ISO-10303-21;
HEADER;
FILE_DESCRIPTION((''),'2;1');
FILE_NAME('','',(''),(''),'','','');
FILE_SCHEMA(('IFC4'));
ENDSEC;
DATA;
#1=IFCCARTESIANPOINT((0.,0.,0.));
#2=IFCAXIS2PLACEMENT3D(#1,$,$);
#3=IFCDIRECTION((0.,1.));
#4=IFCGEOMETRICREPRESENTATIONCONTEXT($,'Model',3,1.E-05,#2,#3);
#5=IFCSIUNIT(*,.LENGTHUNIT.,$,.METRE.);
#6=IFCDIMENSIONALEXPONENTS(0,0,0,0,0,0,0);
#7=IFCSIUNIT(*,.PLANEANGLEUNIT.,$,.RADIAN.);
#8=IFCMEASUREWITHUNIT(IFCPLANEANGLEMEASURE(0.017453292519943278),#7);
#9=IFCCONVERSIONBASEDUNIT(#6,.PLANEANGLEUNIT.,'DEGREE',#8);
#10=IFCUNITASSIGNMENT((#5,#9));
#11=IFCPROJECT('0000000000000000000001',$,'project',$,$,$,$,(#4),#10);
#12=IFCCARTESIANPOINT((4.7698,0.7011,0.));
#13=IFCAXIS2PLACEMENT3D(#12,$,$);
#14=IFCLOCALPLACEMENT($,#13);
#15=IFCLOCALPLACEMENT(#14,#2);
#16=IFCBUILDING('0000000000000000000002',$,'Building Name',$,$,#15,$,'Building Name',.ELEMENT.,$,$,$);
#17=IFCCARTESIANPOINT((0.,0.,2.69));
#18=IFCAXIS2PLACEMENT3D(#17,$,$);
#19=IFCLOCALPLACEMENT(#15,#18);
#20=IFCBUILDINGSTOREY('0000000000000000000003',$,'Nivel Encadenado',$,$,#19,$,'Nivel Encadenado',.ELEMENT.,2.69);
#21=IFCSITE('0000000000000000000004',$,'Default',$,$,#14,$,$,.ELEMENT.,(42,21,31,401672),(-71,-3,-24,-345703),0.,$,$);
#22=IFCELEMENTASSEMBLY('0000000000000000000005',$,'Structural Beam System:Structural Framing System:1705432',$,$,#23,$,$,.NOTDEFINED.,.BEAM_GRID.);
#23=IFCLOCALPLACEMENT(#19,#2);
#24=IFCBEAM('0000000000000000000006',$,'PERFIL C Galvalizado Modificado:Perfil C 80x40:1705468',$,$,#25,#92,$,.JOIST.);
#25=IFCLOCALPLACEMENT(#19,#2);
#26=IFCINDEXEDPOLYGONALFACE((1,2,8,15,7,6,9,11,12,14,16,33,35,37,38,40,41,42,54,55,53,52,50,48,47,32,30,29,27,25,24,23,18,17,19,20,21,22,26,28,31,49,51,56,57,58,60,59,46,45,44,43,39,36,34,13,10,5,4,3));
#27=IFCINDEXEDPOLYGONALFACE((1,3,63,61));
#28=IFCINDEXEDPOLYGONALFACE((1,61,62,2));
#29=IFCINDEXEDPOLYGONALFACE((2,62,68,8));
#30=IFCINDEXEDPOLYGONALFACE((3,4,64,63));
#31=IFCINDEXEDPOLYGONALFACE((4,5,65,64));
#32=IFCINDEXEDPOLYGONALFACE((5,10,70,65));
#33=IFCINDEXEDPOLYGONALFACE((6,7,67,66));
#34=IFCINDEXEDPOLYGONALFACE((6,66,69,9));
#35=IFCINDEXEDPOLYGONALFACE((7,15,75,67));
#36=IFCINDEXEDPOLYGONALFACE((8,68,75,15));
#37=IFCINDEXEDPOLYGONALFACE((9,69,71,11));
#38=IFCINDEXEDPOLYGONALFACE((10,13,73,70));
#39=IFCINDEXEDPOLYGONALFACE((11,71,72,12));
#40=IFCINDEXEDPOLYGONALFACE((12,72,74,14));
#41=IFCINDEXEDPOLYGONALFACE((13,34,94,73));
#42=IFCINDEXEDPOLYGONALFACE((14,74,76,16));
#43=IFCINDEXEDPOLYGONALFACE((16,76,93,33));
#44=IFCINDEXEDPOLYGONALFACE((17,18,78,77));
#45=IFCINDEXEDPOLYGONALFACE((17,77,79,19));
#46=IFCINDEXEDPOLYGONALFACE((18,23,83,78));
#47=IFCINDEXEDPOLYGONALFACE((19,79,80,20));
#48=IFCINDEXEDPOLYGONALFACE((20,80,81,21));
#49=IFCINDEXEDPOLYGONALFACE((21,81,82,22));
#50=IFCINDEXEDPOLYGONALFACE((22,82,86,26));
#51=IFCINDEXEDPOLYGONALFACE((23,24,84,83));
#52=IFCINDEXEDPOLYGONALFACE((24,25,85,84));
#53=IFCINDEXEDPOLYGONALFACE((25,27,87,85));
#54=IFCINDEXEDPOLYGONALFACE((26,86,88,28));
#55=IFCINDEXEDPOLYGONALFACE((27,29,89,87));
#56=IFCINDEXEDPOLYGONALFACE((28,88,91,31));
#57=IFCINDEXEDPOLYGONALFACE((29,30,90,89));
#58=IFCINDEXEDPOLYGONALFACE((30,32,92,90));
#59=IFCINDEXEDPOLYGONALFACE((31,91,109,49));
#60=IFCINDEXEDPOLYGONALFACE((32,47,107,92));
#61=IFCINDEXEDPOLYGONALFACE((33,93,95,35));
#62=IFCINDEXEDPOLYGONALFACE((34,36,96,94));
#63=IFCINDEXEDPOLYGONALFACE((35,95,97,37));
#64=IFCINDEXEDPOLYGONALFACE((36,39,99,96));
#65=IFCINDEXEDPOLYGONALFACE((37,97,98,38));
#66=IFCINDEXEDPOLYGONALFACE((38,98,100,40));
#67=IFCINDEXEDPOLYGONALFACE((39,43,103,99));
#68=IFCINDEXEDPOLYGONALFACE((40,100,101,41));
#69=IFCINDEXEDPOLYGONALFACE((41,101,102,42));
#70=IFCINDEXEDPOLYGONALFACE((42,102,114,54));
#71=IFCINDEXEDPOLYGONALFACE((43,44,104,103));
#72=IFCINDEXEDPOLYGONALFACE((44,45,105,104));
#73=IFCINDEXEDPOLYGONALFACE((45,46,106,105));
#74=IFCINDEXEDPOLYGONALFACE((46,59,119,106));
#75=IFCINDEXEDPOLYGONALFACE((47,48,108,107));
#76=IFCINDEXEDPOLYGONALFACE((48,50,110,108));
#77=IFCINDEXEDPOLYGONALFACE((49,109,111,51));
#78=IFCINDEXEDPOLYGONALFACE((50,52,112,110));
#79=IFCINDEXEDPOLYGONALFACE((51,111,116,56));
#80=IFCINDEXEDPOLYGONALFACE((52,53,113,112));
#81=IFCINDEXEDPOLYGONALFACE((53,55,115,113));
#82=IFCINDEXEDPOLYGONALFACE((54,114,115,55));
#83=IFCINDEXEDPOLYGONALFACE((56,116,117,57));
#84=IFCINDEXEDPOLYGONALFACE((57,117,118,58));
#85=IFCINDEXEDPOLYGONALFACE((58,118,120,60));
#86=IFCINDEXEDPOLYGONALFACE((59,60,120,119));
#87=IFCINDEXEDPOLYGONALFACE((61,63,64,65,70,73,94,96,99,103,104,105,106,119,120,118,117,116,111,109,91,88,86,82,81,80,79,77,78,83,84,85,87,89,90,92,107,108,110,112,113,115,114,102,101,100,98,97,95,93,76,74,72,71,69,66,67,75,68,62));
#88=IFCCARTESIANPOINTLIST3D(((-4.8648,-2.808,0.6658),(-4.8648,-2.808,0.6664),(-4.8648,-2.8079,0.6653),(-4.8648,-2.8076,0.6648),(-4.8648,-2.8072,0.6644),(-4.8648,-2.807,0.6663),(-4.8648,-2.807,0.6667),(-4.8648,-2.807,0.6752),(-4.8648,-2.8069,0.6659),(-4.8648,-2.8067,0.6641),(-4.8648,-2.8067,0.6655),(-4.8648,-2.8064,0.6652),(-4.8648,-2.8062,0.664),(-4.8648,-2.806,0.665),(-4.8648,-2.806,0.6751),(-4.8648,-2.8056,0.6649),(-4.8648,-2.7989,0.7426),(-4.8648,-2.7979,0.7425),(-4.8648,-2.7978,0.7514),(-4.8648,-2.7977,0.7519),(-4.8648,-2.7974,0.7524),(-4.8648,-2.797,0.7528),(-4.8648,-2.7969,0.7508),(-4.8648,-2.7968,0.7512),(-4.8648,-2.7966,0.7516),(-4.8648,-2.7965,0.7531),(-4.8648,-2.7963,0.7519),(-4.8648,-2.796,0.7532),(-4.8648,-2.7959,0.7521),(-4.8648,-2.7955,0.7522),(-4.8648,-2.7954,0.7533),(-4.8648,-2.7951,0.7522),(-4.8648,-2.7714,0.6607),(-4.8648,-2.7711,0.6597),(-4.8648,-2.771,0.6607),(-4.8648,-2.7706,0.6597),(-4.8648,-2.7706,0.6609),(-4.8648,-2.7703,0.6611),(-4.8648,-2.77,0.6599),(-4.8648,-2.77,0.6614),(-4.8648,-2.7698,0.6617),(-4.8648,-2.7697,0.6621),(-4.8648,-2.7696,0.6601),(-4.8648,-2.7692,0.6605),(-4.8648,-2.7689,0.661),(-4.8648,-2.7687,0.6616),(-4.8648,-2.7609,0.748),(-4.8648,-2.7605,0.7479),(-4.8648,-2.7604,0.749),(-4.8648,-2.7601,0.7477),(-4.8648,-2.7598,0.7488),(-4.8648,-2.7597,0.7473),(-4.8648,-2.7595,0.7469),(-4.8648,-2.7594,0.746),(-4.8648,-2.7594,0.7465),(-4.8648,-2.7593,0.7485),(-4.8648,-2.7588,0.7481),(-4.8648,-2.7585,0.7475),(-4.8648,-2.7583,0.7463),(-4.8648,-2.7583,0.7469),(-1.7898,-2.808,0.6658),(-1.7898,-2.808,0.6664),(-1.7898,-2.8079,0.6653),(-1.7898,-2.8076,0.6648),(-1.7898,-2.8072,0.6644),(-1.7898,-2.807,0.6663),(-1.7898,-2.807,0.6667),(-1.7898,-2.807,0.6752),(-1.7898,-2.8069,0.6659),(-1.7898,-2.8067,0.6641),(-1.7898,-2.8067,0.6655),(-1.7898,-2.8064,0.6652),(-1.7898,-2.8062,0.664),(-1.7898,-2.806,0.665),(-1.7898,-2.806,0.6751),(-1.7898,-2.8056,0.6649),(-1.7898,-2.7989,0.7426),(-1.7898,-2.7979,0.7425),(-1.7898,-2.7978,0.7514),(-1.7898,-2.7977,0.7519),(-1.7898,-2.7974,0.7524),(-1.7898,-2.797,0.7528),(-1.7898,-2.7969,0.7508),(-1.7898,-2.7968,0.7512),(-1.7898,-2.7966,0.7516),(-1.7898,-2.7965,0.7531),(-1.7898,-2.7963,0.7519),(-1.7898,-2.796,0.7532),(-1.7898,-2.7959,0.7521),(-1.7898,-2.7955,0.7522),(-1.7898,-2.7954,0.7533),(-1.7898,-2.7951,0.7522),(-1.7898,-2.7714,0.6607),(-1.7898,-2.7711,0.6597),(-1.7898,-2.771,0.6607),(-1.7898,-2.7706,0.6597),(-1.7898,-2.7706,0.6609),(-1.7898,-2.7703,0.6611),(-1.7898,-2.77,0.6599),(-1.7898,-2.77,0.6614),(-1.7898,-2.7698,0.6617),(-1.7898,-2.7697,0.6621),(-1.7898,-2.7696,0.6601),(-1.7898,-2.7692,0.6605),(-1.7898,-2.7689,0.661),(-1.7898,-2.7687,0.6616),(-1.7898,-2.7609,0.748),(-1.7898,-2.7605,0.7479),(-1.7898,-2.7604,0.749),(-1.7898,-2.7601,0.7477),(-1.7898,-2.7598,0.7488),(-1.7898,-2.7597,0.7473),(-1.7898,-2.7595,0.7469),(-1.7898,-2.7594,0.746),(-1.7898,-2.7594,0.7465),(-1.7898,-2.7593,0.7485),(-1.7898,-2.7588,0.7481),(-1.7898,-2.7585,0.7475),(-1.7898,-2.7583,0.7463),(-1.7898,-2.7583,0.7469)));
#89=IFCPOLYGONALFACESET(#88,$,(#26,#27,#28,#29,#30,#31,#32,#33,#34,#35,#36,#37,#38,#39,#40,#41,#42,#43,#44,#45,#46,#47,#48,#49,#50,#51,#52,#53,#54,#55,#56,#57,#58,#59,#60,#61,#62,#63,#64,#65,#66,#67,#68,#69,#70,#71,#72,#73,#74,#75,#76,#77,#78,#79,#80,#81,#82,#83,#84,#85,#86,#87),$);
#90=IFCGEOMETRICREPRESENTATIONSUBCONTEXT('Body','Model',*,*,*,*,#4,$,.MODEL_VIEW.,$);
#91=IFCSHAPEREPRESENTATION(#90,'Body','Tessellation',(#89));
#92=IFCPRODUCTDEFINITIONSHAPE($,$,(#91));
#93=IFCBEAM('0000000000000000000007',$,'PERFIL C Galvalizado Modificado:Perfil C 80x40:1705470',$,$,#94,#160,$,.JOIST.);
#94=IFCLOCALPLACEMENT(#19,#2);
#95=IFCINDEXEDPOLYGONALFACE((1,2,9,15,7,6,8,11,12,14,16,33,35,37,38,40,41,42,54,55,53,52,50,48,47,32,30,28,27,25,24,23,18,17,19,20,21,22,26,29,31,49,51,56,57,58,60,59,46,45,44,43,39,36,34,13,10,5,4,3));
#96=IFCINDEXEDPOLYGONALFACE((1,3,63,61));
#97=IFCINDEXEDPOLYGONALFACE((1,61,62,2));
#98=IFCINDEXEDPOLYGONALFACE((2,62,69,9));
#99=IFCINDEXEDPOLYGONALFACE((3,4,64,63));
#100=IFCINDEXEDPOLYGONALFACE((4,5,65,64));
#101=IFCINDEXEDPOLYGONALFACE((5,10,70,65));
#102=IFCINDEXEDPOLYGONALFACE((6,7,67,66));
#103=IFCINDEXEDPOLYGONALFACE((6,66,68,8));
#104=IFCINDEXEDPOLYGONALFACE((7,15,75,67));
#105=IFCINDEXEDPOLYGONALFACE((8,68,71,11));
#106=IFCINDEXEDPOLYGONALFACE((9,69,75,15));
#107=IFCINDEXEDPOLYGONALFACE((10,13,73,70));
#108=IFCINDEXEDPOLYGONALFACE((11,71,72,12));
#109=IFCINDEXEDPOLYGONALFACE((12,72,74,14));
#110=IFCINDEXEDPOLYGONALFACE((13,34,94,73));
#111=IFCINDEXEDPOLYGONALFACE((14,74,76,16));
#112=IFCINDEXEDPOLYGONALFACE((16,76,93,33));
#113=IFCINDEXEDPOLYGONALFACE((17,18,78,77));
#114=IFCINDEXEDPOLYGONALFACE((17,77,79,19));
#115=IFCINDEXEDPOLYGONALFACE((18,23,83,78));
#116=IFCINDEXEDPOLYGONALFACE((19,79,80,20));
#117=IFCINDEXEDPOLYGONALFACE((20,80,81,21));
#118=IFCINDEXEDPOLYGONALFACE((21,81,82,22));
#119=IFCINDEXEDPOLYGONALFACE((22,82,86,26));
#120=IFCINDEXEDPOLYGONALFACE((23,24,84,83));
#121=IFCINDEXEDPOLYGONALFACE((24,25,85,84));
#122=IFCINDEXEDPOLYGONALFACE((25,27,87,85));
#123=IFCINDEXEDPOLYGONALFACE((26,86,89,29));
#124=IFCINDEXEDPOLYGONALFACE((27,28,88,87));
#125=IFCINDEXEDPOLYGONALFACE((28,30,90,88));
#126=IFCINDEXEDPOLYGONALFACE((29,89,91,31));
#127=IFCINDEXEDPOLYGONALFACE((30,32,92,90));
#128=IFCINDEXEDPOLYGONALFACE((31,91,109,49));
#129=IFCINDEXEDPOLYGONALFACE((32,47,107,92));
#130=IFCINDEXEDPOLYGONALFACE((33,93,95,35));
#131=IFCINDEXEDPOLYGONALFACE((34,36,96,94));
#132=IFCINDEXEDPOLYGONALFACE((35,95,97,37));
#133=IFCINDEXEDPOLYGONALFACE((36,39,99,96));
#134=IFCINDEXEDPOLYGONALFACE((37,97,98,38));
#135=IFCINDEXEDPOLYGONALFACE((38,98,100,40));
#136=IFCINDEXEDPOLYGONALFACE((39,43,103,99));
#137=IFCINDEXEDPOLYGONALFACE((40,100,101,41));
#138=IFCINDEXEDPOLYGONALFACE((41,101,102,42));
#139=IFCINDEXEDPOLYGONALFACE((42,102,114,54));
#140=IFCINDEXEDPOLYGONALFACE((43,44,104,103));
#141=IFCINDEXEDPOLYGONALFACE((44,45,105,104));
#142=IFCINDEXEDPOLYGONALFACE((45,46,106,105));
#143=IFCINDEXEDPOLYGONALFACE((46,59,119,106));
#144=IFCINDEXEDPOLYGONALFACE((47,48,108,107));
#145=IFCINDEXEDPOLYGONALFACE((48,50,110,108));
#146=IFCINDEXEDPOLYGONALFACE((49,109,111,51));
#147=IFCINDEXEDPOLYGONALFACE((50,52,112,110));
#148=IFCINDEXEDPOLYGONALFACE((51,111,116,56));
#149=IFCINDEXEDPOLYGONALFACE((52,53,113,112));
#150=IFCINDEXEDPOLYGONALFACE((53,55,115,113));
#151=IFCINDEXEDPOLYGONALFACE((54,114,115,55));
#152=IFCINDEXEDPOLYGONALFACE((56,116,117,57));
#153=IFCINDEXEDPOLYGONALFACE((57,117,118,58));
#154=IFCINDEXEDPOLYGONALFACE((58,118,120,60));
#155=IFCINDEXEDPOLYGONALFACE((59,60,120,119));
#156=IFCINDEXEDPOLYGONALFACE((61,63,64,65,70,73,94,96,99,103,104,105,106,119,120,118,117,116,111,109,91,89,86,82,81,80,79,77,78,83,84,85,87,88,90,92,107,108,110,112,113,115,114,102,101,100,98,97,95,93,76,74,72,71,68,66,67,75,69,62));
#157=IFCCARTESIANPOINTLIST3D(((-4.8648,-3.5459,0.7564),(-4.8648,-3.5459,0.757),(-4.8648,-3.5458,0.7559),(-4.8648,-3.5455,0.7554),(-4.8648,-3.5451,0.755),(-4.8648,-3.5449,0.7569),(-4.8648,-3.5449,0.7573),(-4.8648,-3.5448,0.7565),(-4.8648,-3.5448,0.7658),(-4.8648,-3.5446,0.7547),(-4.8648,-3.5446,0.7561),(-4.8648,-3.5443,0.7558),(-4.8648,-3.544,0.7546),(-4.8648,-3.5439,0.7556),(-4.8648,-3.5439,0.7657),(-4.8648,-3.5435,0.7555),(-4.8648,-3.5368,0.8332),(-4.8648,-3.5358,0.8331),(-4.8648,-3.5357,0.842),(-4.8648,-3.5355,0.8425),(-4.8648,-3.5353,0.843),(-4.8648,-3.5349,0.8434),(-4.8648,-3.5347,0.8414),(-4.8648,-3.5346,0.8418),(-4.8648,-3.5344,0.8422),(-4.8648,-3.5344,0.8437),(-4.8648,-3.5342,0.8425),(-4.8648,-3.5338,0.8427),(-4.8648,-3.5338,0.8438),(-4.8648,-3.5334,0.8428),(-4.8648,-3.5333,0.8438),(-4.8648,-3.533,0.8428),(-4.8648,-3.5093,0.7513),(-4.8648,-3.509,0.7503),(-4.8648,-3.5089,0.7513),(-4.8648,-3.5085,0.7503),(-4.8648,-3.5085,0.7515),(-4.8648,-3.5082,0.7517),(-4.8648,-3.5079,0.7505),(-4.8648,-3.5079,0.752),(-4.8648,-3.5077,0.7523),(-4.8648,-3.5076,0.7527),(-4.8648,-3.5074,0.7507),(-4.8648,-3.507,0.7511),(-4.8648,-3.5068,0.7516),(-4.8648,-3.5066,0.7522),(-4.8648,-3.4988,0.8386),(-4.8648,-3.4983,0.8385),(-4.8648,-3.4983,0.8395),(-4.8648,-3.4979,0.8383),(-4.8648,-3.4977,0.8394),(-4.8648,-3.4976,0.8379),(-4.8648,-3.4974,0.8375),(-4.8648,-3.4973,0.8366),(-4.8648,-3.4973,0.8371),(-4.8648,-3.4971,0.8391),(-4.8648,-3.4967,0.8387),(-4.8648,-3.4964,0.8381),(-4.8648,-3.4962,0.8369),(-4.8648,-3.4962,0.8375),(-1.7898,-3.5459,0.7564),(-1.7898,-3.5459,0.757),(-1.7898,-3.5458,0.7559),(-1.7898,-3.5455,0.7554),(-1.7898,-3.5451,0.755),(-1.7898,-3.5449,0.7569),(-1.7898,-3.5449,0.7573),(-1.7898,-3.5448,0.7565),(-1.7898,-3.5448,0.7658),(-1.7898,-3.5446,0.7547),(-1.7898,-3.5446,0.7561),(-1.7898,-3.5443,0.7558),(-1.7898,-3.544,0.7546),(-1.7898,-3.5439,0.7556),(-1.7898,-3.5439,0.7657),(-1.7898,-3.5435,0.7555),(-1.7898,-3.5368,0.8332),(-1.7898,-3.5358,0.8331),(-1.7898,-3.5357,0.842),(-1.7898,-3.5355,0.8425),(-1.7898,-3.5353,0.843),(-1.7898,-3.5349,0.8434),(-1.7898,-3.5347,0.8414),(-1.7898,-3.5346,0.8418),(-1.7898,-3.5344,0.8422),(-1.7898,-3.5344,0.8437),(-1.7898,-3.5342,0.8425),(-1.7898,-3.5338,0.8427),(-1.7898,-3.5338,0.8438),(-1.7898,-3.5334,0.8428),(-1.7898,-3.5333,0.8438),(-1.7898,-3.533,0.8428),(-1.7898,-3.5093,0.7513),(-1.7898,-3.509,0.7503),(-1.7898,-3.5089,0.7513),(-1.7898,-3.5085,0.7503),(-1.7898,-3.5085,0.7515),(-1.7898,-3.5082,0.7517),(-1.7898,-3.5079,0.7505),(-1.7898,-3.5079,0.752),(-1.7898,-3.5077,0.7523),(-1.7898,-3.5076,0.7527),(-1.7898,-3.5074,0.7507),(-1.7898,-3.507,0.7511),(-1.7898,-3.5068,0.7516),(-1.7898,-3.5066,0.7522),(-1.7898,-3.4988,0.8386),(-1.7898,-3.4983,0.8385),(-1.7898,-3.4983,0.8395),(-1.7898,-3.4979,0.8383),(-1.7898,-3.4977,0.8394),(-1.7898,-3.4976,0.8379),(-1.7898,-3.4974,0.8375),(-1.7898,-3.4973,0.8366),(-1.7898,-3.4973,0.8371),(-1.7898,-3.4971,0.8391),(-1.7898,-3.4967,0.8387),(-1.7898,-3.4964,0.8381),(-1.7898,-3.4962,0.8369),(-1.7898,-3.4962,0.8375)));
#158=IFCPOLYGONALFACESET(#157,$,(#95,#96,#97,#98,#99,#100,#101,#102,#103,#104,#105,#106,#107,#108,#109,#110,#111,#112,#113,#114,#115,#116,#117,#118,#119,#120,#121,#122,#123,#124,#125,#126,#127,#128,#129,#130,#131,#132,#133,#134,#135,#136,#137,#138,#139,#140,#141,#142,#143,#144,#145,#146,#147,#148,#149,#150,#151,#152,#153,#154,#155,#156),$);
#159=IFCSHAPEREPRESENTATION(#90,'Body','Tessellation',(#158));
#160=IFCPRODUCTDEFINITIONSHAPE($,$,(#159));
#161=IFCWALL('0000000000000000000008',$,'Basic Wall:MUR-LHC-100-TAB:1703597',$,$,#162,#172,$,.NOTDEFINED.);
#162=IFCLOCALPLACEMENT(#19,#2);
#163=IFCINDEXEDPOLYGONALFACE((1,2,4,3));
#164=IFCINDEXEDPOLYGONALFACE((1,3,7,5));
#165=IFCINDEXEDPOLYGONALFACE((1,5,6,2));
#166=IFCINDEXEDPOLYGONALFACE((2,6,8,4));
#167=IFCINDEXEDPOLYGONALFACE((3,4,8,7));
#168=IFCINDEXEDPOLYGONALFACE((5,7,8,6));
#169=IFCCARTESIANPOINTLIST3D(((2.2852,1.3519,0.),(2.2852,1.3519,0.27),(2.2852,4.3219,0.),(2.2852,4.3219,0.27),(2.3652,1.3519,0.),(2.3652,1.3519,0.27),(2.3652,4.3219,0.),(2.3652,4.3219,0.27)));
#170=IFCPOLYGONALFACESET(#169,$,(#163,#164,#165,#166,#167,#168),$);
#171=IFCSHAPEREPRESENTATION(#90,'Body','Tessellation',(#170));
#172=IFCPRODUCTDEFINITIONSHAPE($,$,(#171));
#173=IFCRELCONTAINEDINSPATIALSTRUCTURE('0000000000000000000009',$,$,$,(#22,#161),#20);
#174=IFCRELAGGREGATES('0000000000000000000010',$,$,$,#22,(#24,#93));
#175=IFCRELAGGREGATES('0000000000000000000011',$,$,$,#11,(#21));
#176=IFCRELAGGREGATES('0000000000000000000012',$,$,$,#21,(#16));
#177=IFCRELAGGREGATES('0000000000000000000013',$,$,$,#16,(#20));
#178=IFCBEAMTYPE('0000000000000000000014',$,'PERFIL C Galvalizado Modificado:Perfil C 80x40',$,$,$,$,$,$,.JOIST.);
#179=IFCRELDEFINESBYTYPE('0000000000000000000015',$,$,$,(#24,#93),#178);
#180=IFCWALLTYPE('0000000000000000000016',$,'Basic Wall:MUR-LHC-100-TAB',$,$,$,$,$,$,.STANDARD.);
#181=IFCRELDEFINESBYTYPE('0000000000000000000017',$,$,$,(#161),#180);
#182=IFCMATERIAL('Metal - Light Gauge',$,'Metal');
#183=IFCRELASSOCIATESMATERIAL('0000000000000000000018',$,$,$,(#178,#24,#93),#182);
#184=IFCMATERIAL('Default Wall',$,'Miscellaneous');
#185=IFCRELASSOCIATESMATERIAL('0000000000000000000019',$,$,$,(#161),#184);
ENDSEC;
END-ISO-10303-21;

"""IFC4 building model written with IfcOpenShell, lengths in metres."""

from ifc_helpers import new_model, entity, si_unit, converted_unit, direction, frame, origin, place, context, subcontext, project, spatial, line, arc, indexed_curve, outline, extrude, source, transform, mapped, material, type_object, type_shapes, element, aggregate, save


model = new_model("IFC4")

# Units and contexts
model_context = context("Model", 3, precision=1e-05, world=origin(), true_north=direction((0.0, 1.0)))
body_context = subcontext(model_context, "Body", "Model", "MODEL_VIEW")
ifc_project = project(units=[si_unit("LENGTHUNIT", "METRE"), converted_unit("PLANEANGLEUNIT", "DEGREE", entity("IfcPlaneAngleMeasure", 0.017453292519943278), si_unit("PLANEANGLEUNIT", "RADIAN"), dimensions=[0, 0, 0, 0, 0, 0, 0])], contexts=[model_context])

# Site, building, storey
site_placement = place(None, frame((4.7698, 0.7011, 0.0)))
site = spatial("IfcSite", under=ifc_project, at=site_placement, Name="Default", CompositionType="ELEMENT", RefLatitude=(42, 21, 31, 401672), RefLongitude=(-71, -3, -24, -345703), RefElevation=0.0)
building_placement = place(site_placement, origin())
building = spatial("IfcBuilding", under=site, at=building_placement, Name="Building Name", LongName="Building Name", CompositionType="ELEMENT")
storey_placement = place(building_placement, frame((0.0, 0.0, 2.69)))
storey = spatial("IfcBuildingStorey", under=building, at=storey_placement, Name="Nivel Encadenado", LongName="Nivel Encadenado", CompositionType="ELEMENT", Elevation=2.69)

# Element assembly, beams
ifc_material_1 = material(Name="Metal - Light Gauge", Category="Metal")
assembly_1_placement = place(storey_placement, origin())
assembly_1 = element("IfcElementAssembly", 1, at=assembly_1_placement, inside=storey, Name="Structural Beam System:Structural Framing System:1705432", AssemblyPlace="NOTDEFINED", PredefinedType="BEAM_GRID")
beam_type_1 = type_object("IfcBeamType", Name="PERFIL C Galvalizado Modificado:Perfil C 80x40", PredefinedType="JOIST", material=ifc_material_1)
shared_shape_1 = source(origin(), body_context, "Body", "SweptSolid", [
    extrude(outline(indexed_curve([(-0.0428, -0.0161), (-0.034, -0.0161), (-0.034, -0.0151), (-0.0424, -0.0151), (-0.0435, -0.0146), (-0.044, -0.0135), (-0.044, 0.021), (-0.0435, 0.0222), (-0.0422, 0.0227), (0.0424, 0.0227), (0.0435, 0.0223), (0.0439, 0.0212), (0.0439, -0.0133), (0.0435, -0.0144), (0.0424, -0.0149), (0.0339, -0.0149), (0.0339, -0.0159), (0.0428, -0.0159), (0.0443, -0.0152), (0.0449, -0.0137), (0.0449, 0.0216), (0.0443, 0.0231), (0.0428, 0.0237), (-0.0426, 0.0237), (-0.0443, 0.023), (-0.045, 0.0214), (-0.045, -0.0139), (-0.0443, -0.0154)], segments=[line(1, 2, 3, 4), arc(4, 5, 6), line(6, 7), arc(7, 8, 9), line(9, 10), arc(10, 11, 12), line(12, 13), arc(13, 14, 15), line(15, 16, 17, 18), arc(18, 19, 20), line(20, 21), arc(21, 22, 23), line(23, 24), arc(24, 25, 26), line(26, 27), arc(27, 28, 1)], self_intersect=False)), frame((-1.5375, -0.0037, 0.0), z_axis=(1.0, 0.0, 0.0), x_axis=(0.0, 0.0, -1.0)), (0.0, 0.0, 1.0), 3.075),
])
type_shapes(beam_type_1, [shared_shape_1])
beam_1_placement = place(assembly_1_placement, frame((-3.3273, -2.7834, 0.7065), z_axis=(0.0, 0.121869, 0.992546), x_axis=(1.0, 0.0, 0.0)))
beam_1 = element("IfcBeam", 2, at=beam_1_placement, type_object=beam_type_1, material=ifc_material_1, Name="PERFIL C Galvalizado Modificado:Perfil C 80x40:1705468", PredefinedType="JOIST", context=body_context, shape_type="MappedRepresentation", body=[
    mapped(shared_shape_1, transform((0.0, 0.0, 0.0), scale=1.0)),
])
beam_2_placement = place(assembly_1_placement, frame((-3.3273, -3.5213, 0.7971), z_axis=(0.0, 0.121869, 0.992546), x_axis=(1.0, 0.0, 0.0)))
beam_2 = element("IfcBeam", 3, at=beam_2_placement, type_object=beam_type_1, material=ifc_material_1, Name="PERFIL C Galvalizado Modificado:Perfil C 80x40:1705470", PredefinedType="JOIST", context=body_context, shape_type="MappedRepresentation", body=[
    mapped(shared_shape_1, transform((0.0, 0.0, 0.0), scale=1.0)),
])
aggregate(assembly_1, [beam_1, beam_2])

# Wall
ifc_material_2 = material(Name="Default Wall", Category="Miscellaneous")
wall_type_1 = type_object("IfcWallType", Name="Basic Wall:MUR-LHC-100-TAB", PredefinedType="STANDARD")
wall_1_placement = place(storey_placement, frame((2.3252, 1.3519, 0.0), z_axis=(0.0, 0.0, 1.0), x_axis=(0.0, 1.0, 0.0)))
element("IfcWall", 4, at=wall_1_placement, inside=storey, type_object=wall_type_1, material=ifc_material_2, Name="Basic Wall:MUR-LHC-100-TAB:1703597", PredefinedType="NOTDEFINED", context=body_context, shape_type="SweptSolid", body=[
    extrude(outline(indexed_curve([(2.97, 0.04), (0.0, 0.04), (0.0, -0.04), (2.97, -0.04), (2.97, 0.04)], self_intersect=False)), origin(), (0.0, 0.0, 1.0), 0.27),
])

save(model, "model.ifc")
